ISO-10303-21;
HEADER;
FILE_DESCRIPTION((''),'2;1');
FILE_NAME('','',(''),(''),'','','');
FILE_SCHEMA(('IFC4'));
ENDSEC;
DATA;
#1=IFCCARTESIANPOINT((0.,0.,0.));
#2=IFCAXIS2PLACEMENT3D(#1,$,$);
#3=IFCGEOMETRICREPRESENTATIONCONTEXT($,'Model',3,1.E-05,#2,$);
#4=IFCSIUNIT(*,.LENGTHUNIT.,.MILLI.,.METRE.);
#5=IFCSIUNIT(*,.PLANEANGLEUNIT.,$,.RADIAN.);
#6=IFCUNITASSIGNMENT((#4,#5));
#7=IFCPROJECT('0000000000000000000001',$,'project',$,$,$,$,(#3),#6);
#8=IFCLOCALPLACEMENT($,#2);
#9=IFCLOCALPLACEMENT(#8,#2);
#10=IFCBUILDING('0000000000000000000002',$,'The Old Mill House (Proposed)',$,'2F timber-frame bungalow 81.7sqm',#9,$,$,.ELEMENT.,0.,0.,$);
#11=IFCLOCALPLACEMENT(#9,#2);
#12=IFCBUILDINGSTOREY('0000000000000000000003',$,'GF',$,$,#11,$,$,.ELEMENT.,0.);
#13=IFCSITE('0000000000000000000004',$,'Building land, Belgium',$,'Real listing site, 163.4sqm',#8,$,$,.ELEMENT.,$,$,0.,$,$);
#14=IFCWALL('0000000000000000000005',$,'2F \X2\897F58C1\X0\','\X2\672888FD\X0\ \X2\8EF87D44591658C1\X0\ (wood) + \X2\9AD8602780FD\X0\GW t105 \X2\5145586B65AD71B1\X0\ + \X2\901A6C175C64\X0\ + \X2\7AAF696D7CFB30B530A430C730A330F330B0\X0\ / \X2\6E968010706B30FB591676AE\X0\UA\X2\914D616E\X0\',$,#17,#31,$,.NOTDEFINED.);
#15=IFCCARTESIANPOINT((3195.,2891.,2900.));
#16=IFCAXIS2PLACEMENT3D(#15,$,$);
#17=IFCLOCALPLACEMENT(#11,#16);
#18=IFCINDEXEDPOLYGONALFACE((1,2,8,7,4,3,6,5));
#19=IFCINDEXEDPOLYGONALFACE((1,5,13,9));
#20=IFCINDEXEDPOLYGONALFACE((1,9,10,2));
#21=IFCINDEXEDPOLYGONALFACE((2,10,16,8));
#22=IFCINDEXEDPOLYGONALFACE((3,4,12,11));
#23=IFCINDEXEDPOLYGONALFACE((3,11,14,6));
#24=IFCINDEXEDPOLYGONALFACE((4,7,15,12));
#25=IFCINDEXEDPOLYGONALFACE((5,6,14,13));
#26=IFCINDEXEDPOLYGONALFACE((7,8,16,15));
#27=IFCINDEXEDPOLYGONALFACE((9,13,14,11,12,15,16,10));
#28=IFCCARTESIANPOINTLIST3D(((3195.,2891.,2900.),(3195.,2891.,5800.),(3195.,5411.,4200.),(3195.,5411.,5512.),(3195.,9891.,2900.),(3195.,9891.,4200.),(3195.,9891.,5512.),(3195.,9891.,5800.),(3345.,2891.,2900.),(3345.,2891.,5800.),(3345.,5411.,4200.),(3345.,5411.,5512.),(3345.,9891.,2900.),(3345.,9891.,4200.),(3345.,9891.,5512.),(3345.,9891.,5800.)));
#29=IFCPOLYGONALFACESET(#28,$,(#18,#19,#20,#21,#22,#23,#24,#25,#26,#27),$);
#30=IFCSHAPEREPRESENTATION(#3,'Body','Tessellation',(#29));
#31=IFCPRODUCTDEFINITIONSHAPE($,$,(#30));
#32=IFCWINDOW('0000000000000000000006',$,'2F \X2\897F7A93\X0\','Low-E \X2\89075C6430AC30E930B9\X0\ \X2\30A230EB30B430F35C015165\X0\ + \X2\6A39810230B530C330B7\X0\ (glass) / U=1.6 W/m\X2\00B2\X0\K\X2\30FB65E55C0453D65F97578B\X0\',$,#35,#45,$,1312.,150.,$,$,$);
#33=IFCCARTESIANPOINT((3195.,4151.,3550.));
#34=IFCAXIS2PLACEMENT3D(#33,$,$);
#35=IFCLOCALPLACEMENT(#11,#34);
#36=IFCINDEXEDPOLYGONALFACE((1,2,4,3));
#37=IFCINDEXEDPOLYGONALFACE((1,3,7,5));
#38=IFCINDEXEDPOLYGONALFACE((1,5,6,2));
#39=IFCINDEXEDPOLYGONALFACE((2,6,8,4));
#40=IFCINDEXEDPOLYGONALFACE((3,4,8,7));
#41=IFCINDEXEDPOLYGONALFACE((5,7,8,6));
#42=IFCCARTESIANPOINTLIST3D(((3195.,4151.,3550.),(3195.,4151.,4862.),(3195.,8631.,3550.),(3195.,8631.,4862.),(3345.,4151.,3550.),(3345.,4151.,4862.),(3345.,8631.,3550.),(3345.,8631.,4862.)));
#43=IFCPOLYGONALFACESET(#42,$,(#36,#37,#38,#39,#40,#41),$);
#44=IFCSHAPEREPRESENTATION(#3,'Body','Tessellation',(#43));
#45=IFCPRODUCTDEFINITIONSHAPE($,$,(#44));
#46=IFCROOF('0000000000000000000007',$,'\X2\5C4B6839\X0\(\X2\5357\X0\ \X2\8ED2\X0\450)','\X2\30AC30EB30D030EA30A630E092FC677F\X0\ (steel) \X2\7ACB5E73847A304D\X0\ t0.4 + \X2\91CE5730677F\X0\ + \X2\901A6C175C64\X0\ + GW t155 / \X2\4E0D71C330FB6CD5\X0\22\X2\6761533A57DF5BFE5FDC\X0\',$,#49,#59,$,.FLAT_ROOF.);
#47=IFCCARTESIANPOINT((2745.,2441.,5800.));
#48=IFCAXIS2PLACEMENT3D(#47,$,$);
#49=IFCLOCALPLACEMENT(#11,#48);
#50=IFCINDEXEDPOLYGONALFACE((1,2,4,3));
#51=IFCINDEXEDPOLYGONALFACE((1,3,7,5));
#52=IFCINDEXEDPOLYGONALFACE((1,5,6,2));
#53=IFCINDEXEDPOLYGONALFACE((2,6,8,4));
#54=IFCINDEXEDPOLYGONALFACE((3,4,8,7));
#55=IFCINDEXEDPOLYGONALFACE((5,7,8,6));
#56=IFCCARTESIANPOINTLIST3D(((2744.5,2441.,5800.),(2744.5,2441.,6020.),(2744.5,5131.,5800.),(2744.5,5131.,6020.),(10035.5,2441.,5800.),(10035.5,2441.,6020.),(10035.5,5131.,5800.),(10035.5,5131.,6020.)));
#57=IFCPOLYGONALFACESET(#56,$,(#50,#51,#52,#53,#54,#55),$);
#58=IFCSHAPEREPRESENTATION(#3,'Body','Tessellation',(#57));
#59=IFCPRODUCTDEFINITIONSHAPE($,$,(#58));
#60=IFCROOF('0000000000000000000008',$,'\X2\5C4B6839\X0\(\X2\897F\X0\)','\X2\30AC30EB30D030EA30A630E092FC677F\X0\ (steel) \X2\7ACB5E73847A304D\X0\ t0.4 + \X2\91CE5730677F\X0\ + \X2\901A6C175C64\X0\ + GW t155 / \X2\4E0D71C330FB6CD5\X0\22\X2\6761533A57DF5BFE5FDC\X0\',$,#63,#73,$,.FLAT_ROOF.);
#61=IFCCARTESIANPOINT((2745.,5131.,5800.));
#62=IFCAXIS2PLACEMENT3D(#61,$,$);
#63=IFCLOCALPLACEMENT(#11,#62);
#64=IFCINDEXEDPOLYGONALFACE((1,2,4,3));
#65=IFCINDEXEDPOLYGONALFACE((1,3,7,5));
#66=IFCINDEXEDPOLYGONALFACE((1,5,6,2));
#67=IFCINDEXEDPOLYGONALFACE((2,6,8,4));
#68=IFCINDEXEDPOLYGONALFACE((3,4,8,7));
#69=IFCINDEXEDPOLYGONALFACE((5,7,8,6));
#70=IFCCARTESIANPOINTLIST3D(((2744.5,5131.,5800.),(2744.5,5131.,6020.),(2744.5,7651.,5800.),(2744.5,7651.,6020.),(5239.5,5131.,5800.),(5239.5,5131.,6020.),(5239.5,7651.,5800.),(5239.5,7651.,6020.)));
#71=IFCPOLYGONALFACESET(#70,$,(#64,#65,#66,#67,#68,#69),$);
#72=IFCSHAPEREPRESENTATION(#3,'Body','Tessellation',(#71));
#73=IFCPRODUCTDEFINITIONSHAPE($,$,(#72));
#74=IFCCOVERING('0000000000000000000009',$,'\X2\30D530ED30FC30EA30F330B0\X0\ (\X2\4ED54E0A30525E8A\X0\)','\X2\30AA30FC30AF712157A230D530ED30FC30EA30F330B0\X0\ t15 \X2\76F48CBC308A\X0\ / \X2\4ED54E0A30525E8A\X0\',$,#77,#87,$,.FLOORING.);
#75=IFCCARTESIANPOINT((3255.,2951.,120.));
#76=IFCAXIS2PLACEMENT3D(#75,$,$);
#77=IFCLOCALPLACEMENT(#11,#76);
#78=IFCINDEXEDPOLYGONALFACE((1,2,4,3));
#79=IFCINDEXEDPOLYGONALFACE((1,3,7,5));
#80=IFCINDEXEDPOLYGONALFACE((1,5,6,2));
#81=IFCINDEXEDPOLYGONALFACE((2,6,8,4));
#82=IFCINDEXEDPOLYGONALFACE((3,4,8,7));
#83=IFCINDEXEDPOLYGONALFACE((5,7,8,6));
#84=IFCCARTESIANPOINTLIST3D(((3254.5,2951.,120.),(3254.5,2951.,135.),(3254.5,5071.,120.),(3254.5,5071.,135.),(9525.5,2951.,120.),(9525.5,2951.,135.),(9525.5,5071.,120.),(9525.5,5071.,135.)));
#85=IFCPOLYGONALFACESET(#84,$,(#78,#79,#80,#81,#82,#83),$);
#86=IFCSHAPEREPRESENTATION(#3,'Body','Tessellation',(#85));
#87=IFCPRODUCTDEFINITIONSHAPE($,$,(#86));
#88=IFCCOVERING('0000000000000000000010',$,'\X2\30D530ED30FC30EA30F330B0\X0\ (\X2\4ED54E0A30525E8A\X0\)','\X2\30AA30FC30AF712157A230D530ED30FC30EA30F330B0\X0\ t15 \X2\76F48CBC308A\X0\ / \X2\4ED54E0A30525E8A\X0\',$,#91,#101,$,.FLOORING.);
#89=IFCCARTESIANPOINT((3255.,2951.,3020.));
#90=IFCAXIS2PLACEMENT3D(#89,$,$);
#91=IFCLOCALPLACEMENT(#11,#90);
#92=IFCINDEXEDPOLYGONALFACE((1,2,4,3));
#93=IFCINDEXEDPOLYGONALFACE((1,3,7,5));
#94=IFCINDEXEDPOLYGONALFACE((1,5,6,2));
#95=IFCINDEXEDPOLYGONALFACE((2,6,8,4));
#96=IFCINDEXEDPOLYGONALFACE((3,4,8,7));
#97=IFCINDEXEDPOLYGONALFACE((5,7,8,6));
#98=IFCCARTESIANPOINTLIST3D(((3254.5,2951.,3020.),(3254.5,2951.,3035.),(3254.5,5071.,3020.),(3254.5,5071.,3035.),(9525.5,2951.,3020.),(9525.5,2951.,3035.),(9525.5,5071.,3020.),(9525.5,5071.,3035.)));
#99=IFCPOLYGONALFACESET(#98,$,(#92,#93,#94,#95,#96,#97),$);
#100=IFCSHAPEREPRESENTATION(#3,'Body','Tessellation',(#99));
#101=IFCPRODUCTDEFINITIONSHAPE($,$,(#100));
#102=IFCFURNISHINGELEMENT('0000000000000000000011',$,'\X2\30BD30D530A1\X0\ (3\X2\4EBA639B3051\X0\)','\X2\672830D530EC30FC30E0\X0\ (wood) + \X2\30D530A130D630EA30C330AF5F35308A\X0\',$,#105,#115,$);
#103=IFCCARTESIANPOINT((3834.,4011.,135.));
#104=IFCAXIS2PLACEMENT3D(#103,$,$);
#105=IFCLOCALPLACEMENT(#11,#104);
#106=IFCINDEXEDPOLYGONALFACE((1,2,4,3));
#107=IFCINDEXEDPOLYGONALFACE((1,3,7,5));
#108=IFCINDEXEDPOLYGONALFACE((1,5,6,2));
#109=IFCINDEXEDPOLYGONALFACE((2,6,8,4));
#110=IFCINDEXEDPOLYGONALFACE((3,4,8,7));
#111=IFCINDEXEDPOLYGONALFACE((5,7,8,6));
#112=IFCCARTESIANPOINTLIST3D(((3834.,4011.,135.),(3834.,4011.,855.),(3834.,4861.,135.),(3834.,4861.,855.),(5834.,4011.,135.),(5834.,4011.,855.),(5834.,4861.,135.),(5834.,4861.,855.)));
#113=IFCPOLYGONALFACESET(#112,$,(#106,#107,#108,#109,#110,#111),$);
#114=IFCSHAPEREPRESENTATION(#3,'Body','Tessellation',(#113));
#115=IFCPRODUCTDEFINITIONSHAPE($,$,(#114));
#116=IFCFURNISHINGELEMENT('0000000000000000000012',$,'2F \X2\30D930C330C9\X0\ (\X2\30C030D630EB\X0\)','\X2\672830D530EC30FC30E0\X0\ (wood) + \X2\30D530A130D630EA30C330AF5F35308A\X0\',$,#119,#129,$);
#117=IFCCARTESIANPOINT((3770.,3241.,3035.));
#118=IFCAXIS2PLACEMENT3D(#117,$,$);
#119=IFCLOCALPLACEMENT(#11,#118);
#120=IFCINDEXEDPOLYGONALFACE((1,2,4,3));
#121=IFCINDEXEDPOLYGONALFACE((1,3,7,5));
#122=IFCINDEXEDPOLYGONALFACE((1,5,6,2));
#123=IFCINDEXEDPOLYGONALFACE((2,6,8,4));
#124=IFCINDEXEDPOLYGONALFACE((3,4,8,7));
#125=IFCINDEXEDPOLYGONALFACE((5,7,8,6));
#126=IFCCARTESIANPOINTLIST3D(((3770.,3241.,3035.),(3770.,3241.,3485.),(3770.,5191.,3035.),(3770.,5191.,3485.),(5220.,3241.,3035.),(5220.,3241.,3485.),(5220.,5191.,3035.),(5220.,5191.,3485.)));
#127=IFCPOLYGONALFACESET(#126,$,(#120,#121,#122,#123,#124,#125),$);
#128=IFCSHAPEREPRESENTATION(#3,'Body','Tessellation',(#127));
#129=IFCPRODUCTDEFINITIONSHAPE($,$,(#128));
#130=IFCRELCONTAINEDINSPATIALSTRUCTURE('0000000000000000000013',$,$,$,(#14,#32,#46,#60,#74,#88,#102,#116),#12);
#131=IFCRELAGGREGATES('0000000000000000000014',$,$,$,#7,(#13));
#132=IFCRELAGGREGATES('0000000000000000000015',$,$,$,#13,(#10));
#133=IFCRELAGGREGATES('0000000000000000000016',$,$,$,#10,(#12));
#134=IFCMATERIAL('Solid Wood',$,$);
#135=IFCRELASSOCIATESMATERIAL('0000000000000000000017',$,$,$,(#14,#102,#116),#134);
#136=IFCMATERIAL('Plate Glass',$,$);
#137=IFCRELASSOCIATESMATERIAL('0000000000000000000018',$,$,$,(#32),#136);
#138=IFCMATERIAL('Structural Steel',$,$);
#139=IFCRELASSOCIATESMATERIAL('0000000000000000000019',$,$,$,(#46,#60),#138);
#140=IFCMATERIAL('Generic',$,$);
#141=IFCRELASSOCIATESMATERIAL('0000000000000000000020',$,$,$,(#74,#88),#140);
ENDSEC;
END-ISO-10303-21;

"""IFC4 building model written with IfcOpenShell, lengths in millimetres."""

from ifc_helpers import new_model, si_unit, frame, frame_2d, origin, place, context, project, spatial, rectangle, extrude, material, element, fill, save


model = new_model("IFC4")

# Units and contexts
model_context = context("Model", 3, precision=1e-05, world=origin())
ifc_project = project(units=[si_unit("LENGTHUNIT", "METRE", prefix="MILLI"), si_unit("PLANEANGLEUNIT", "RADIAN")], contexts=[model_context])

# Site, building, storey
site_placement = place(None, origin())
site = spatial("IfcSite", under=ifc_project, at=site_placement, Name="Building land, Belgium", ObjectType="Real listing site, 163.4sqm", CompositionType="ELEMENT", RefElevation=0.0)
building_placement = place(site_placement, origin())
building = spatial("IfcBuilding", under=site, at=building_placement, Name="The Old Mill House (Proposed)", ObjectType="2F timber-frame bungalow 81.7sqm", CompositionType="ELEMENT", ElevationOfRefHeight=0.0, ElevationOfTerrain=0.0)
storey_placement = place(building_placement, origin())
storey = spatial("IfcBuildingStorey", under=building, at=storey_placement, Name="GF", CompositionType="ELEMENT", Elevation=0.0)

# Shared definitions
ifc_material_1 = material(Name="Solid Wood")

# Shared definitions
ifc_material_2 = material(Name="Plate Glass")

# Wall, opening, window
wall_1_placement = place(storey_placement, frame((3195.0, 2891.0, 2900.0)))
wall_1 = element("IfcWall", 1, at=wall_1_placement, inside=storey, material=ifc_material_1, Name="2F 西壁", Description="木製 軸組外壁 (wood) + 高性能GW t105 充填断熱 + 通気層 + 窯業系サイディング / 準耐火・外皮UA配慮", PredefinedType="NOTDEFINED", context=model_context, shape_type="SweptSolid", body=[
    extrude(rectangle(XDim=150.0, YDim=7000.0, at=frame_2d((75.0, 3500.0))), frame((3195.0, 2891.0, 2900.0)), (0.0, 0.0, 1.0), 2900.0),
])
opening_1_placement = place(storey_placement, frame((3195.0, 4151.0, 3550.0)))
opening_1 = element("IfcOpeningElement", 2, at=opening_1_placement, cuts=wall_1, PredefinedType="NOTDEFINED", context=model_context, shape_type="SweptSolid", body=[
    extrude(rectangle(XDim=150.0, YDim=4480.0, at=frame_2d((75.0, 2240.0))), frame((3195.0, 4151.0, 3550.0)), (0.0, 0.0, 1.0), 1312.0),
])
window_1_placement = place(storey_placement, frame((3195.0, 4151.0, 3550.0)))
window_1 = element("IfcWindow", 3, at=window_1_placement, inside=storey, material=ifc_material_2, Name="2F 西窓", Description="Low-E 複層ガラス アルゴン封入 + 樹脂サッシ (glass) / U=1.6 W/m²K・日射取得型", OverallHeight=1312.0, OverallWidth=150.0, context=model_context, shape_type="SweptSolid", body=[
    extrude(rectangle(XDim=150.0, YDim=4480.0, at=frame_2d((75.0, 2240.0))), frame((3195.0, 4151.0, 3550.0)), (0.0, 0.0, 1.0), 1312.0),
])
fill(opening_1, window_1)

# Roofs
ifc_material_3 = material(Name="Structural Steel")
roof_1_placement = place(storey_placement, frame((2745.0, 2441.0, 5800.0)))
element("IfcRoof", 4, at=roof_1_placement, inside=storey, material=ifc_material_3, Name="屋根(南 軒450)", Description="ガルバリウム鋼板 (steel) 立平葺き t0.4 + 野地板 + 通気層 + GW t155 / 不燃・法22条区域対応", PredefinedType="FLAT_ROOF", context=model_context, shape_type="SweptSolid", body=[
    extrude(rectangle(XDim=7291.0, YDim=2690.0, at=frame_2d((3645.0, 1345.0))), frame((2745.0, 2441.0, 5800.0)), (0.0, 0.0, 1.0), 220.0),
])
roof_2_placement = place(storey_placement, frame((2745.0, 5131.0, 5800.0)))
element("IfcRoof", 5, at=roof_2_placement, inside=storey, material=ifc_material_3, Name="屋根(西)", Description="ガルバリウム鋼板 (steel) 立平葺き t0.4 + 野地板 + 通気層 + GW t155 / 不燃・法22条区域対応", PredefinedType="FLAT_ROOF", context=model_context, shape_type="SweptSolid", body=[
    extrude(rectangle(XDim=2495.0, YDim=2520.0, at=frame_2d((1247.0, 1260.0))), frame((2745.0, 5131.0, 5800.0)), (0.0, 0.0, 1.0), 220.0),
])

# Coverings
ifc_material_4 = material(Name="Generic")
covering_1_placement = place(storey_placement, frame((3255.0, 2951.0, 120.0)))
element("IfcCovering", 6, at=covering_1_placement, inside=storey, material=ifc_material_4, Name="フローリング (仕上げ床)", Description="オーク無垢フローリング t15 直貼り / 仕上げ床", PredefinedType="FLOORING", context=model_context, shape_type="SweptSolid", body=[
    extrude(rectangle(XDim=6271.0, YDim=2120.0, at=frame_2d((3135.0, 1060.0))), frame((3255.0, 2951.0, 120.0)), (0.0, 0.0, 1.0), 15.0),
])
covering_2_placement = place(storey_placement, frame((3255.0, 2951.0, 3020.0)))
element("IfcCovering", 7, at=covering_2_placement, inside=storey, material=ifc_material_4, Name="フローリング (仕上げ床)", Description="オーク無垢フローリング t15 直貼り / 仕上げ床", PredefinedType="FLOORING", context=model_context, shape_type="SweptSolid", body=[
    extrude(rectangle(XDim=6271.0, YDim=2120.0, at=frame_2d((3135.0, 1060.0))), frame((3255.0, 2951.0, 3020.0)), (0.0, 0.0, 1.0), 15.0),
])

# Furnishing elements
furnishing_1_placement = place(storey_placement, frame((3834.0, 4011.0, 135.0)))
element("IfcFurnishingElement", 8, at=furnishing_1_placement, inside=storey, material=ifc_material_1, Name="ソファ (3人掛け)", Description="木フレーム (wood) + ファブリック張り", context=model_context, shape_type="SweptSolid", body=[
    extrude(rectangle(XDim=2000.0, YDim=850.0, at=frame_2d((1000.0, 425.0))), frame((3834.0, 4011.0, 135.0)), (0.0, 0.0, 1.0), 720.0),
])
furnishing_2_placement = place(storey_placement, frame((3770.0, 3241.0, 3035.0)))
element("IfcFurnishingElement", 9, at=furnishing_2_placement, inside=storey, material=ifc_material_1, Name="2F ベッド (ダブル)", Description="木フレーム (wood) + ファブリック張り", context=model_context, shape_type="SweptSolid", body=[
    extrude(rectangle(XDim=1450.0, YDim=1950.0, at=frame_2d((725.0, 975.0))), frame((3770.0, 3241.0, 3035.0)), (0.0, 0.0, 1.0), 450.0),
])

save(model, "model.ifc")
